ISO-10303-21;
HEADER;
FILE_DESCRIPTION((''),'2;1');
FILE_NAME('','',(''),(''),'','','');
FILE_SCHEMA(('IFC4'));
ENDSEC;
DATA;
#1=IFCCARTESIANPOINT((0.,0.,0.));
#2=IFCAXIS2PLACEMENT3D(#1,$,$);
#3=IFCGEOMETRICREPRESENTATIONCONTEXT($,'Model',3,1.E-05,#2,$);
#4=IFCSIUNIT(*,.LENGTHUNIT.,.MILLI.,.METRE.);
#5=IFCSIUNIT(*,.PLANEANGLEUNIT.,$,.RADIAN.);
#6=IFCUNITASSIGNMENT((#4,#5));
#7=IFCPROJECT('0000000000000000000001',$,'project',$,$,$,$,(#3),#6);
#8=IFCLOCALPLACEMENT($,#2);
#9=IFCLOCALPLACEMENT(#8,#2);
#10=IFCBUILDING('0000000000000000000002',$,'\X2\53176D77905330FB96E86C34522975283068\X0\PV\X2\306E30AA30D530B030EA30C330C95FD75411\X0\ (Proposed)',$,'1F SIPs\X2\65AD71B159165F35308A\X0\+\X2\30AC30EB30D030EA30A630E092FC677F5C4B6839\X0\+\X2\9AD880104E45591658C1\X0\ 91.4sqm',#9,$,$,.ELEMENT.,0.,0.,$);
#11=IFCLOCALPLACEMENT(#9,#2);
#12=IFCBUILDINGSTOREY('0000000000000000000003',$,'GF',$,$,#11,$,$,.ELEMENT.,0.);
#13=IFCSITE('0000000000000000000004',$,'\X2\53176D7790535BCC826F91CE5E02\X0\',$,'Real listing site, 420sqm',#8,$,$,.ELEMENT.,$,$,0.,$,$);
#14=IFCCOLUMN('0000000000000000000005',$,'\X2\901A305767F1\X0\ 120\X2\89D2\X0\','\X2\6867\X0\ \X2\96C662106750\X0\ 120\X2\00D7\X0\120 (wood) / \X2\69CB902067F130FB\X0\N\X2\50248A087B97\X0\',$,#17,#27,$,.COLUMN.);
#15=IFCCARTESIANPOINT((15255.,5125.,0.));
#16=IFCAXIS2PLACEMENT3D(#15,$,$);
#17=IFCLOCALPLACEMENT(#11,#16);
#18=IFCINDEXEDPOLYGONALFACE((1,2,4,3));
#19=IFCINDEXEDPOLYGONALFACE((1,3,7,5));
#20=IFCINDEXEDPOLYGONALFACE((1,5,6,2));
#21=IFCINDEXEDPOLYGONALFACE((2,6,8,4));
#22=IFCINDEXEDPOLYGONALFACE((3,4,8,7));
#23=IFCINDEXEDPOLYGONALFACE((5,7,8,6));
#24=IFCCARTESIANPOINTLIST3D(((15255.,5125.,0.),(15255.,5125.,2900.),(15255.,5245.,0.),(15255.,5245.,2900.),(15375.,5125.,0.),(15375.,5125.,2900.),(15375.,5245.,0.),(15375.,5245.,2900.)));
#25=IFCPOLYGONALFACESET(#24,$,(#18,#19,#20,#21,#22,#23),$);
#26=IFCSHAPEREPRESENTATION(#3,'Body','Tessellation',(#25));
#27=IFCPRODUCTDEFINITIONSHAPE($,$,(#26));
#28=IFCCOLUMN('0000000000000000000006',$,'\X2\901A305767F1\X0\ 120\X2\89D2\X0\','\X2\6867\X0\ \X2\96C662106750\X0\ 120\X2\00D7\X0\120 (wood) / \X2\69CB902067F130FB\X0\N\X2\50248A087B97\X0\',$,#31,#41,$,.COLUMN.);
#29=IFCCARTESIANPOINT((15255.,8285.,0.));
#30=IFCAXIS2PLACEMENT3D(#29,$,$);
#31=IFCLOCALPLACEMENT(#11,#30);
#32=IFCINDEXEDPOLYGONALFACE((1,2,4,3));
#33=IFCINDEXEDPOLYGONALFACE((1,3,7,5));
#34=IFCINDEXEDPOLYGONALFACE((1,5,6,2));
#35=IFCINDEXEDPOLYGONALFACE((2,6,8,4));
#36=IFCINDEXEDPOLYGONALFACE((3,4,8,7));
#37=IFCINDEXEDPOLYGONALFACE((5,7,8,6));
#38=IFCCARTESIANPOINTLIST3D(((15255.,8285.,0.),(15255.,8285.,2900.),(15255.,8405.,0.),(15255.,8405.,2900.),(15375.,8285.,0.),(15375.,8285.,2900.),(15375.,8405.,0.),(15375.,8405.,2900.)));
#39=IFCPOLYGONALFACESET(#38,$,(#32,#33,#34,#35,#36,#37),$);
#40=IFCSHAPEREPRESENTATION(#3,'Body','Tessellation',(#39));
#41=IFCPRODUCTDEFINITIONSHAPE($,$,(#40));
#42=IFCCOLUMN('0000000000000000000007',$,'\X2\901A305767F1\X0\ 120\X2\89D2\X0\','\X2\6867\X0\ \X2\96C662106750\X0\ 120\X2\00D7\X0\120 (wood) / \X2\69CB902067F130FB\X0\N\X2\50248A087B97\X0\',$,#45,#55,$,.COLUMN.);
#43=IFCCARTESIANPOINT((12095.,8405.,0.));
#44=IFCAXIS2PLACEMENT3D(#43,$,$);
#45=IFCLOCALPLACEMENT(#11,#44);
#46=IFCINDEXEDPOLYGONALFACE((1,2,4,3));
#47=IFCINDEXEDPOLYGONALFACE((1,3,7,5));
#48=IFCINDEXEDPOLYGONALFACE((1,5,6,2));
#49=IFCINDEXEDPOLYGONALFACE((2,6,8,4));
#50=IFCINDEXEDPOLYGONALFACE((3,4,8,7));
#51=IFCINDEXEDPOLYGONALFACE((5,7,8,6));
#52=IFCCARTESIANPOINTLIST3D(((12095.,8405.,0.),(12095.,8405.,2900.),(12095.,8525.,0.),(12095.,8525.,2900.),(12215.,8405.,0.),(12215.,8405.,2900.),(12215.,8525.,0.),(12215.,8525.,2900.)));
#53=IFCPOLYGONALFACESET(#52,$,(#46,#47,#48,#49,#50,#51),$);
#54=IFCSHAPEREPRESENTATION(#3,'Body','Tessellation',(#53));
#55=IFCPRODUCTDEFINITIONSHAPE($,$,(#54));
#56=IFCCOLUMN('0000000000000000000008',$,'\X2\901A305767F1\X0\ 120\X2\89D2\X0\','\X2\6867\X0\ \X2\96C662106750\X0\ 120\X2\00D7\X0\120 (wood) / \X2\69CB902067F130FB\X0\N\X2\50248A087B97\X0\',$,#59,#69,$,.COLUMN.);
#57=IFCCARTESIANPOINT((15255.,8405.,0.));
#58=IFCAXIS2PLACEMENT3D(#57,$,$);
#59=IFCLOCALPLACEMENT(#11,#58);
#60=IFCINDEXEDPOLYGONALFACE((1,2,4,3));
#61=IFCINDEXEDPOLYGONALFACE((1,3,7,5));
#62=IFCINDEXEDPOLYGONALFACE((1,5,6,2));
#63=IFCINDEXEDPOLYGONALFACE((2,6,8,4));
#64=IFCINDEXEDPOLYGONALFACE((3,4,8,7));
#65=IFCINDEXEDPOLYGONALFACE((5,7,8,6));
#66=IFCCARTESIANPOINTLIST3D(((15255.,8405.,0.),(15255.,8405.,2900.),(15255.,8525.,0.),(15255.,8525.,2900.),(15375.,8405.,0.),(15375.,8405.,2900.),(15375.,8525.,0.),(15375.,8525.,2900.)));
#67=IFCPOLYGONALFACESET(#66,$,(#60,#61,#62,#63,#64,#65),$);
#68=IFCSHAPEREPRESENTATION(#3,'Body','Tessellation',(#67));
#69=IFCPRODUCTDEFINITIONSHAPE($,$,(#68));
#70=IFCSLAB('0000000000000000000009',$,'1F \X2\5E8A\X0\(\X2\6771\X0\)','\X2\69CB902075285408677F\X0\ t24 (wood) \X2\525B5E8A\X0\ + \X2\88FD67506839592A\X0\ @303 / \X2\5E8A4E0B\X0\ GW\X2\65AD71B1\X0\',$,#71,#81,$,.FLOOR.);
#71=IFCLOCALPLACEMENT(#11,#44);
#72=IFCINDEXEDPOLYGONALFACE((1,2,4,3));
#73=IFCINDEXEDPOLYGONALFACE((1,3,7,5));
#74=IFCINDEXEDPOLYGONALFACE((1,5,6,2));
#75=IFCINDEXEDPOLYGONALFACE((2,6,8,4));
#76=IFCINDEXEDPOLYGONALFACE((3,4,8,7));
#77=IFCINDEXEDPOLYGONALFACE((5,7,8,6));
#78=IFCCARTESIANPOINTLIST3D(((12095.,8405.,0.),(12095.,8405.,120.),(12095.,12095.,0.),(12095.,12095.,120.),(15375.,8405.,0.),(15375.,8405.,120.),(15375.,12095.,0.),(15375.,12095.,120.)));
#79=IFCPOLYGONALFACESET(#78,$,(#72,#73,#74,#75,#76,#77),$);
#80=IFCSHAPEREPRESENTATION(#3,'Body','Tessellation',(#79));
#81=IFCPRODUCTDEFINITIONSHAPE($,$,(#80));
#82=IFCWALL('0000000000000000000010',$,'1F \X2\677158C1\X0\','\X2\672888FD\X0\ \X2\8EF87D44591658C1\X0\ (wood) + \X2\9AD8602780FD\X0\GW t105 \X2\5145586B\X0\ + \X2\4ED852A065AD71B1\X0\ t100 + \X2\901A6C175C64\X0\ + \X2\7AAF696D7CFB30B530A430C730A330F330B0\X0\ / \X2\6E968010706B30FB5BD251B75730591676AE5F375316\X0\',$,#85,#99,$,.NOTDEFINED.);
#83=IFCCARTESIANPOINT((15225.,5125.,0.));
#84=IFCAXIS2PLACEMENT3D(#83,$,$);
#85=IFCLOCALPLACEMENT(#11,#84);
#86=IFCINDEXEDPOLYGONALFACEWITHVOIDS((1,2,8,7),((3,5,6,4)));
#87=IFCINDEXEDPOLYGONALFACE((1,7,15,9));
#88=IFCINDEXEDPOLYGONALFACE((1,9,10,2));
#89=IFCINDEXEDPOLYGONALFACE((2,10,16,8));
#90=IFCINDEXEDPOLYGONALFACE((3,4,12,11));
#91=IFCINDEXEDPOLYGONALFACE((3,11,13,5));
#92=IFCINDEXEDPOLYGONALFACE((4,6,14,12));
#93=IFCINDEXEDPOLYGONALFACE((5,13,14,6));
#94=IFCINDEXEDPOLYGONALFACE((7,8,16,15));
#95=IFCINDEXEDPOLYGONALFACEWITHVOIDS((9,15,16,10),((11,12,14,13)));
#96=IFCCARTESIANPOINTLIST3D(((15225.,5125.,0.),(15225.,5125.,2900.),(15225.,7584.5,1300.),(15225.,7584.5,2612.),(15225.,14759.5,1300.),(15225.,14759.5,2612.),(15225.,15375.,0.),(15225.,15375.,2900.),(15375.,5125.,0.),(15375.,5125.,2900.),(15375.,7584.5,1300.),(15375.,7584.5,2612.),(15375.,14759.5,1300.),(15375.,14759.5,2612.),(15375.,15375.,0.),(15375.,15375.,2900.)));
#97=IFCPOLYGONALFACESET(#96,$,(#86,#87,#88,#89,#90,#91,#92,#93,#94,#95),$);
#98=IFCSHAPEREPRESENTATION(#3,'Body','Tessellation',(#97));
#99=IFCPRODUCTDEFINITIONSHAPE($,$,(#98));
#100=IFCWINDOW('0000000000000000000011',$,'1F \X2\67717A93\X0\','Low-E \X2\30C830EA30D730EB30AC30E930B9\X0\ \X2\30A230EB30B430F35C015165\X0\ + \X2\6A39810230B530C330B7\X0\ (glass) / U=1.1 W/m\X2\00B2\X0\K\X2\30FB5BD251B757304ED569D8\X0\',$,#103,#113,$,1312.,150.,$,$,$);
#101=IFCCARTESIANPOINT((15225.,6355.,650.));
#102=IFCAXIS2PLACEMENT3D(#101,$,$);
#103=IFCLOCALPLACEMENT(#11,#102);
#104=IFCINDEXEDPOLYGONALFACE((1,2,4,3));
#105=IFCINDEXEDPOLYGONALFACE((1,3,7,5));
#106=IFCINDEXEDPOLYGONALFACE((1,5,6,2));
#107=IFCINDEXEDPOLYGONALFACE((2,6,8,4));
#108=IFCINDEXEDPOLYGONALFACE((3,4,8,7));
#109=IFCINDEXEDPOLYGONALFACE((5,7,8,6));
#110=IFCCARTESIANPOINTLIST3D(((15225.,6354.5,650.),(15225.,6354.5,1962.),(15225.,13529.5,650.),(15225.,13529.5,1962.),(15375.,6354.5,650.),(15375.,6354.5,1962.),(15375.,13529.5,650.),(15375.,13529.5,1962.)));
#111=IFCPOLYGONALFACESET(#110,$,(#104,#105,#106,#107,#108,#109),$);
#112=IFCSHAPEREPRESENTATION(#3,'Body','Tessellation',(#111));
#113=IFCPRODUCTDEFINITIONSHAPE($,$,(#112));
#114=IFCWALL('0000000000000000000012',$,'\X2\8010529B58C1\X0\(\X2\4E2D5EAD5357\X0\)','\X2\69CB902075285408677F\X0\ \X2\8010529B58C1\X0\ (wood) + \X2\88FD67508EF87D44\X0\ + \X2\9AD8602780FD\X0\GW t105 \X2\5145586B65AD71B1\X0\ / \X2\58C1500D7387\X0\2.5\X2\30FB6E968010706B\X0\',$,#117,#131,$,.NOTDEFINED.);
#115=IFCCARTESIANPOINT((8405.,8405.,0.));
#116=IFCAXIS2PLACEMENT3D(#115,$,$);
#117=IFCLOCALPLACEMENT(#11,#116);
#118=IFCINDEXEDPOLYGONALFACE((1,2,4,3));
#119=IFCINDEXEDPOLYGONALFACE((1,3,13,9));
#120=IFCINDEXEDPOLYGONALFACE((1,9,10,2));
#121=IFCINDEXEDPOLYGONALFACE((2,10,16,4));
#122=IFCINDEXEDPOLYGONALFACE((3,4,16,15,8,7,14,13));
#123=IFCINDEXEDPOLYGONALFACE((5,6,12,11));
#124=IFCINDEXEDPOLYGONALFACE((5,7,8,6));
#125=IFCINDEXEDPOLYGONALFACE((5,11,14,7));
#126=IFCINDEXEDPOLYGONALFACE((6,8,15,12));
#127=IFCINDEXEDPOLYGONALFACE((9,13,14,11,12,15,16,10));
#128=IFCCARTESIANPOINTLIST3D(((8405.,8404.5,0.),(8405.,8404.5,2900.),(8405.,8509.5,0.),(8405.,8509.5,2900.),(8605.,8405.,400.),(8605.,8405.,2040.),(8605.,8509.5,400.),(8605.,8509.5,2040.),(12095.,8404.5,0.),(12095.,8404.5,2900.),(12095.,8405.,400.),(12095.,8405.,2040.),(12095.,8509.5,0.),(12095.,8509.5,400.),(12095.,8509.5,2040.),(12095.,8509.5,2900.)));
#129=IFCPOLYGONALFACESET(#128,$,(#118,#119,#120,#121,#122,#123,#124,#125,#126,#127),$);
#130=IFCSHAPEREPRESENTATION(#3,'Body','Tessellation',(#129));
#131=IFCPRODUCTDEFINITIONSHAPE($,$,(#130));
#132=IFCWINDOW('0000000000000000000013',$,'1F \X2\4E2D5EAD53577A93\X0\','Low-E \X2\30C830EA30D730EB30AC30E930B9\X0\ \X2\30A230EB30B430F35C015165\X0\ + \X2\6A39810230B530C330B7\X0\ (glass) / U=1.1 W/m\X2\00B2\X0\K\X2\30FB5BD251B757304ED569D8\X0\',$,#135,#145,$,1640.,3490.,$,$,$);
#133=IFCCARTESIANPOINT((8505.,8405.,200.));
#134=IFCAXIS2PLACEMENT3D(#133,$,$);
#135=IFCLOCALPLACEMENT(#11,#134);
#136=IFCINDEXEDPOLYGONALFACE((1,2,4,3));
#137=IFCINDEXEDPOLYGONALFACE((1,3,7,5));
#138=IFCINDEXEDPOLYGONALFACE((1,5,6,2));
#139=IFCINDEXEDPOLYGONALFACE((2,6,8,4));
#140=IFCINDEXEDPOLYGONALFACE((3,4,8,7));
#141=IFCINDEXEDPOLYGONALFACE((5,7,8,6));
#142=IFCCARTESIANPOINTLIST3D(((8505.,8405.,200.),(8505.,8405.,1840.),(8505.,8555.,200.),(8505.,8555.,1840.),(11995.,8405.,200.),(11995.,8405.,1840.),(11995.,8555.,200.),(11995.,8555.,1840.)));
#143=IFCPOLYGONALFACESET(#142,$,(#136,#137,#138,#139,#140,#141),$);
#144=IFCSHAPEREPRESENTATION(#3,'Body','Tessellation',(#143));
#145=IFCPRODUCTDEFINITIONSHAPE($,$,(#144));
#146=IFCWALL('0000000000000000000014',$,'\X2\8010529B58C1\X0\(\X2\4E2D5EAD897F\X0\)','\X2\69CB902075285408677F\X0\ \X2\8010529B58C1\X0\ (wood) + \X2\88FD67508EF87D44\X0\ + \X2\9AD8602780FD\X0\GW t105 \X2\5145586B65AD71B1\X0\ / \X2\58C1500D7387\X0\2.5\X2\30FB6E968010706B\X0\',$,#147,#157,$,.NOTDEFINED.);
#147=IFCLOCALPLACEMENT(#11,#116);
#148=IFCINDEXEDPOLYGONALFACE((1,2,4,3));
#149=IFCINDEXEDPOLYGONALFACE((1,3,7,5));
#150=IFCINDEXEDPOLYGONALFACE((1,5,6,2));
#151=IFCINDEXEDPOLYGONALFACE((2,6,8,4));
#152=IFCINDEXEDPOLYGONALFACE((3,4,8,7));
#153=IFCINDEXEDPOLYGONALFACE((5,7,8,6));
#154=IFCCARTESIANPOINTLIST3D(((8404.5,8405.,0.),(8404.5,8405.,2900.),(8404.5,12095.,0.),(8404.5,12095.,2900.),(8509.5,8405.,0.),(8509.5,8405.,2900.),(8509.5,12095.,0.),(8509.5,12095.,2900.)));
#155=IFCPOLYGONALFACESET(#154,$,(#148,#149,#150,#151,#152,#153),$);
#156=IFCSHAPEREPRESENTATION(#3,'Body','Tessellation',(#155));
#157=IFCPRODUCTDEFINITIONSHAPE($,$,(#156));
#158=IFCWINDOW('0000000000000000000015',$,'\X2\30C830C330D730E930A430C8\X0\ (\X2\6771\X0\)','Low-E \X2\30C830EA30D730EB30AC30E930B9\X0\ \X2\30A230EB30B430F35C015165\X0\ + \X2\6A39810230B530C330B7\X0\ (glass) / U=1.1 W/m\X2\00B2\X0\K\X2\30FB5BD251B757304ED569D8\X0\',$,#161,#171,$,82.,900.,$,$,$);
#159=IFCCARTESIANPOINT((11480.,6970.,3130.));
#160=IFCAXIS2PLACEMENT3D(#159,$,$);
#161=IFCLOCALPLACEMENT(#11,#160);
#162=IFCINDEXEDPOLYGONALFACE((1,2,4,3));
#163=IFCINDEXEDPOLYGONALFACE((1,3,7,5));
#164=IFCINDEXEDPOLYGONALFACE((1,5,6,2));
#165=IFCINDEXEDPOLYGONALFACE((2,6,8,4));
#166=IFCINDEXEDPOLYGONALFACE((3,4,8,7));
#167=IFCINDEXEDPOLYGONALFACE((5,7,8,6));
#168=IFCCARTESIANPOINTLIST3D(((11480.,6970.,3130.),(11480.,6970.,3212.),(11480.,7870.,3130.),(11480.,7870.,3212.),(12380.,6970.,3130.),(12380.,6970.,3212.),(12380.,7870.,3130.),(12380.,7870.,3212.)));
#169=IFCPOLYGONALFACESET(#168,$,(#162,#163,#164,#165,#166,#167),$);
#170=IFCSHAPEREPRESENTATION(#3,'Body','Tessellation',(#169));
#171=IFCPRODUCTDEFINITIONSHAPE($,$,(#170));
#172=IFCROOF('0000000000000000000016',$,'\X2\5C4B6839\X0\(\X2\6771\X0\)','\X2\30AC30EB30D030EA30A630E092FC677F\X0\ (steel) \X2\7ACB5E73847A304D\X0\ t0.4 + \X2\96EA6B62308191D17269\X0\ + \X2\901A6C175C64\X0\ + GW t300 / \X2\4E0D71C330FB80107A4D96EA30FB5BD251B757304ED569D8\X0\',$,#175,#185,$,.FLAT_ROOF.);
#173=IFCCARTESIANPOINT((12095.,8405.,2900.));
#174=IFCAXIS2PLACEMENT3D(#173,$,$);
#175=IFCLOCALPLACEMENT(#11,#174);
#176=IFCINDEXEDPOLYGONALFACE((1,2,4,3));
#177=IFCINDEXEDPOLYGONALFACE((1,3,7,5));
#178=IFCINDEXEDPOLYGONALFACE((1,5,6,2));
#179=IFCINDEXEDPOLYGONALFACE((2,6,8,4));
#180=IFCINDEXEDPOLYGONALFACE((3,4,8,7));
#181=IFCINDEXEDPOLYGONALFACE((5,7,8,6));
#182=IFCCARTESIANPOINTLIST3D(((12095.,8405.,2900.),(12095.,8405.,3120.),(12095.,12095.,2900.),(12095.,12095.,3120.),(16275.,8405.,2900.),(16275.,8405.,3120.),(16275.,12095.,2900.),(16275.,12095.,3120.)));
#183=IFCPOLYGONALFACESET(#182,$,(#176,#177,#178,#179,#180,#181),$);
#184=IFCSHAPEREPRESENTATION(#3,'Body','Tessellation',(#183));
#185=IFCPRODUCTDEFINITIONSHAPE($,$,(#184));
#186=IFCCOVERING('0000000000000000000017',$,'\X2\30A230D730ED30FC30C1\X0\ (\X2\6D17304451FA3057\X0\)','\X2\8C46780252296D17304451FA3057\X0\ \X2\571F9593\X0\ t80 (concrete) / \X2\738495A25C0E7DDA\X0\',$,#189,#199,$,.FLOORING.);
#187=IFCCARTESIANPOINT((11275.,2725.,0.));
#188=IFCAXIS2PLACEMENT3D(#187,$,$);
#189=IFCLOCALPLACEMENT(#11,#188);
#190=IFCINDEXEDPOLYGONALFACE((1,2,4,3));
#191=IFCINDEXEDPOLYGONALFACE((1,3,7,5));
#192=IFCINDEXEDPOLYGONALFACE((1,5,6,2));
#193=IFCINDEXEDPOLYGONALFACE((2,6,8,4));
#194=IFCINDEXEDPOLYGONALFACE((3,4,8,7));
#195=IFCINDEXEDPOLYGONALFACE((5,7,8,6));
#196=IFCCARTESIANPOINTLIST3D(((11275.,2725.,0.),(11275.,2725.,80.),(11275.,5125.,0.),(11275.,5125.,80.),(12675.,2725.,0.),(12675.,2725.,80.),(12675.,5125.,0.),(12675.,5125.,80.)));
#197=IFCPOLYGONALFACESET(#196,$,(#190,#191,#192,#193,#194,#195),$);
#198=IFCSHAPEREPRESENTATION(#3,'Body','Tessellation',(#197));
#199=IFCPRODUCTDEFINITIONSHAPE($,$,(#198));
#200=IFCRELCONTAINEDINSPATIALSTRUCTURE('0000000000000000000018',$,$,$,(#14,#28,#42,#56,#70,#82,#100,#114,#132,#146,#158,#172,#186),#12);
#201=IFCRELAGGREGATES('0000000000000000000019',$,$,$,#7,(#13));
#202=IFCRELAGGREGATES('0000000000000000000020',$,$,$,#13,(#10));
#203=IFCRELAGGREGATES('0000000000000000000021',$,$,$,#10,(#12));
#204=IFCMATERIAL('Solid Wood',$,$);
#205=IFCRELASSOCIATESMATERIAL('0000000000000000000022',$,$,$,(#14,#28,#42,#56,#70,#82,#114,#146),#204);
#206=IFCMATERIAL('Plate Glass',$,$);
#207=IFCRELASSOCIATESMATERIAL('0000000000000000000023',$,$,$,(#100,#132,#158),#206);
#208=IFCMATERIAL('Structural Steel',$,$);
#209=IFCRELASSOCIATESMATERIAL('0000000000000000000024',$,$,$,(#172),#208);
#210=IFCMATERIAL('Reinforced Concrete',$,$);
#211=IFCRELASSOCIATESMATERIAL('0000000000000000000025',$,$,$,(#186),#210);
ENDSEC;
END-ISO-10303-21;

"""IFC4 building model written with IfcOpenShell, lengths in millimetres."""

from ifc_helpers import new_model, si_unit, frame, frame_2d, origin, place, context, project, spatial, rectangle, extrude, material, element, fill, save


model = new_model("IFC4")

# Units and contexts
model_context = context("Model", 3, precision=1e-05, world=origin())
ifc_project = project(units=[si_unit("LENGTHUNIT", "METRE", prefix="MILLI"), si_unit("PLANEANGLEUNIT", "RADIAN")], contexts=[model_context])

# Site, building, storey
site_placement = place(None, origin())
site = spatial("IfcSite", under=ifc_project, at=site_placement, Name="北海道富良野市", ObjectType="Real listing site, 420sqm", CompositionType="ELEMENT", RefElevation=0.0)
building_placement = place(site_placement, origin())
building = spatial("IfcBuilding", under=site, at=building_placement, Name="北海道・雨水利用とPVのオフグリッド志向 (Proposed)", ObjectType="1F SIPs断熱外張り+ガルバリウム鋼板屋根+高耐久外壁 91.4sqm", CompositionType="ELEMENT", ElevationOfRefHeight=0.0, ElevationOfTerrain=0.0)
storey_placement = place(building_placement, origin())
storey = spatial("IfcBuildingStorey", under=building, at=storey_placement, Name="GF", CompositionType="ELEMENT", Elevation=0.0)

# Columns
ifc_material_1 = material(Name="Solid Wood")
column_1_placement = place(storey_placement, frame((15255.0, 5125.0, 0.0)))
element("IfcColumn", 1, at=column_1_placement, inside=storey, material=ifc_material_1, Name="通し柱 120角", Description="桧 集成材 120×120 (wood) / 構造柱・N値計算", PredefinedType="COLUMN", context=model_context, shape_type="SweptSolid", body=[
    extrude(rectangle(XDim=120.0, YDim=120.0, at=frame_2d((60.0, 60.0))), frame((15255.0, 5125.0, 0.0)), (0.0, 0.0, 1.0), 2900.0),
])
column_2_placement = place(storey_placement, frame((15255.0, 8285.0, 0.0)))
element("IfcColumn", 2, at=column_2_placement, inside=storey, material=ifc_material_1, Name="通し柱 120角", Description="桧 集成材 120×120 (wood) / 構造柱・N値計算", PredefinedType="COLUMN", context=model_context, shape_type="SweptSolid", body=[
    extrude(rectangle(XDim=120.0, YDim=120.0, at=frame_2d((60.0, 60.0))), frame((15255.0, 8285.0, 0.0)), (0.0, 0.0, 1.0), 2900.0),
])
column_3_placement = place(storey_placement, frame((12095.0, 8405.0, 0.0)))
element("IfcColumn", 3, at=column_3_placement, inside=storey, material=ifc_material_1, Name="通し柱 120角", Description="桧 集成材 120×120 (wood) / 構造柱・N値計算", PredefinedType="COLUMN", context=model_context, shape_type="SweptSolid", body=[
    extrude(rectangle(XDim=120.0, YDim=120.0, at=frame_2d((60.0, 60.0))), frame((12095.0, 8405.0, 0.0)), (0.0, 0.0, 1.0), 2900.0),
])
column_4_placement = place(storey_placement, frame((15255.0, 8405.0, 0.0)))
element("IfcColumn", 4, at=column_4_placement, inside=storey, material=ifc_material_1, Name="通し柱 120角", Description="桧 集成材 120×120 (wood) / 構造柱・N値計算", PredefinedType="COLUMN", context=model_context, shape_type="SweptSolid", body=[
    extrude(rectangle(XDim=120.0, YDim=120.0, at=frame_2d((60.0, 60.0))), frame((15255.0, 8405.0, 0.0)), (0.0, 0.0, 1.0), 2900.0),
])

# Slab
slab_placement = place(storey_placement, frame((12095.0, 8405.0, 0.0)))
element("IfcSlab", 5, at=slab_placement, inside=storey, material=ifc_material_1, Name="1F 床(東)", Description="構造用合板 t24 (wood) 剛床 + 製材根太 @303 / 床下 GW断熱", PredefinedType="FLOOR", context=model_context, shape_type="SweptSolid", body=[
    extrude(rectangle(XDim=3280.0, YDim=3690.0, at=frame_2d((1640.0, 1845.0))), frame((12095.0, 8405.0, 0.0)), (0.0, 0.0, 1.0), 120.0),
])

# Walls, openings, windows
wall_1_placement = place(storey_placement, frame((15225.0, 5125.0, 0.0)))
wall_1 = element("IfcWall", 6, at=wall_1_placement, inside=storey, material=ifc_material_1, Name="1F 東壁", Description="木製 軸組外壁 (wood) + 高性能GW t105 充填 + 付加断熱 t100 + 通気層 + 窯業系サイディング / 準耐火・寒冷地外皮強化", PredefinedType="NOTDEFINED", context=model_context, shape_type="SweptSolid", body=[
    extrude(rectangle(XDim=150.0, YDim=10250.0, at=frame_2d((75.0, 5125.0))), frame((15225.0, 5125.0, 0.0)), (0.0, 0.0, 1.0), 2900.0),
])
opening_1_placement = place(storey_placement, frame((15225.0, 6355.0, 650.0)))
opening_1 = element("IfcOpeningElement", 7, at=opening_1_placement, cuts=wall_1, PredefinedType="NOTDEFINED", context=model_context, shape_type="SweptSolid", body=[
    extrude(rectangle(XDim=150.0, YDim=7175.0, at=frame_2d((75.0, 3587.0))), frame((15225.0, 6355.0, 650.0)), (0.0, 0.0, 1.0), 1312.0),
])
ifc_material_2 = material(Name="Plate Glass")
window_1_placement = place(storey_placement, frame((15225.0, 6355.0, 650.0)))
window_1 = element("IfcWindow", 8, at=window_1_placement, inside=storey, material=ifc_material_2, Name="1F 東窓", Description="Low-E トリプルガラス アルゴン封入 + 樹脂サッシ (glass) / U=1.1 W/m²K・寒冷地仕様", OverallHeight=1312.0, OverallWidth=150.0, context=model_context, shape_type="SweptSolid", body=[
    extrude(rectangle(XDim=150.0, YDim=7175.0, at=frame_2d((75.0, 3587.0))), frame((15225.0, 6355.0, 650.0)), (0.0, 0.0, 1.0), 1312.0),
])
fill(opening_1, window_1)
wall_2_placement = place(storey_placement, frame((8405.0, 8405.0, 0.0)))
wall_2 = element("IfcWall", 9, at=wall_2_placement, inside=storey, material=ifc_material_1, Name="耐力壁(中庭南)", Description="構造用合板 耐力壁 (wood) + 製材軸組 + 高性能GW t105 充填断熱 / 壁倍率2.5・準耐火", PredefinedType="NOTDEFINED", context=model_context, shape_type="SweptSolid", body=[
    extrude(rectangle(XDim=3690.0, YDim=105.0, at=frame_2d((1845.0, 52.0))), frame((8405.0, 8405.0, 0.0)), (0.0, 0.0, 1.0), 2900.0),
])
opening_2_placement = place(storey_placement, frame((8505.0, 8405.0, 200.0)))
opening_2 = element("IfcOpeningElement", 10, at=opening_2_placement, cuts=wall_2, PredefinedType="NOTDEFINED", context=model_context, shape_type="SweptSolid", body=[
    extrude(rectangle(XDim=3490.0, YDim=150.0, at=frame_2d((1745.0, 75.0))), frame((8505.0, 8405.0, 200.0)), (0.0, 0.0, 1.0), 1640.0),
])
window_2_placement = place(storey_placement, frame((8505.0, 8405.0, 200.0)))
window_2 = element("IfcWindow", 11, at=window_2_placement, inside=storey, material=ifc_material_2, Name="1F 中庭南窓", Description="Low-E トリプルガラス アルゴン封入 + 樹脂サッシ (glass) / U=1.1 W/m²K・寒冷地仕様", OverallHeight=1640.0, OverallWidth=3490.0, context=model_context, shape_type="SweptSolid", body=[
    extrude(rectangle(XDim=3490.0, YDim=150.0, at=frame_2d((1745.0, 75.0))), frame((8505.0, 8405.0, 200.0)), (0.0, 0.0, 1.0), 1640.0),
])
fill(opening_2, window_2)

# Wall
wall_3_placement = place(storey_placement, frame((8405.0, 8405.0, 0.0)))
element("IfcWall", 12, at=wall_3_placement, inside=storey, material=ifc_material_1, Name="耐力壁(中庭西)", Description="構造用合板 耐力壁 (wood) + 製材軸組 + 高性能GW t105 充填断熱 / 壁倍率2.5・準耐火", PredefinedType="NOTDEFINED", context=model_context, shape_type="SweptSolid", body=[
    extrude(rectangle(XDim=105.0, YDim=3690.0, at=frame_2d((52.0, 1845.0))), frame((8405.0, 8405.0, 0.0)), (0.0, 0.0, 1.0), 2900.0),
])

# Window
window_3_placement = place(storey_placement, frame((11480.0, 6970.0, 3130.0)))
element("IfcWindow", 13, at=window_3_placement, inside=storey, material=ifc_material_2, Name="トップライト (東)", Description="Low-E トリプルガラス アルゴン封入 + 樹脂サッシ (glass) / U=1.1 W/m²K・寒冷地仕様", OverallHeight=82.0, OverallWidth=900.0, context=model_context, shape_type="SweptSolid", body=[
    extrude(rectangle(XDim=900.0, YDim=900.0, at=frame_2d((450.0, 450.0))), frame((11480.0, 6970.0, 3130.0)), (0.0, 0.0, 1.0), 82.0),
])

# Roof
ifc_material_3 = material(Name="Structural Steel")
roof_placement = place(storey_placement, frame((12095.0, 8405.0, 2900.0)))
element("IfcRoof", 14, at=roof_placement, inside=storey, material=ifc_material_3, Name="屋根(東)", Description="ガルバリウム鋼板 (steel) 立平葺き t0.4 + 雪止め金物 + 通気層 + GW t300 / 不燃・耐積雪・寒冷地仕様", PredefinedType="FLAT_ROOF", context=model_context, shape_type="SweptSolid", body=[
    extrude(rectangle(XDim=4180.0, YDim=3690.0, at=frame_2d((2090.0, 1845.0))), frame((12095.0, 8405.0, 2900.0)), (0.0, 0.0, 1.0), 220.0),
])

# Covering
ifc_material_4 = material(Name="Reinforced Concrete")
covering_placement = place(storey_placement, frame((11275.0, 2725.0, 0.0)))
element("IfcCovering", 15, at=covering_placement, inside=storey, material=ifc_material_4, Name="アプローチ (洗い出し)", Description="豆砂利洗い出し 土間 t80 (concrete) / 玄関導線", PredefinedType="FLOORING", context=model_context, shape_type="SweptSolid", body=[
    extrude(rectangle(XDim=1400.0, YDim=2400.0, at=frame_2d((700.0, 1200.0))), frame((11275.0, 2725.0, 0.0)), (0.0, 0.0, 1.0), 80.0),
])

save(model, "model.ifc")
